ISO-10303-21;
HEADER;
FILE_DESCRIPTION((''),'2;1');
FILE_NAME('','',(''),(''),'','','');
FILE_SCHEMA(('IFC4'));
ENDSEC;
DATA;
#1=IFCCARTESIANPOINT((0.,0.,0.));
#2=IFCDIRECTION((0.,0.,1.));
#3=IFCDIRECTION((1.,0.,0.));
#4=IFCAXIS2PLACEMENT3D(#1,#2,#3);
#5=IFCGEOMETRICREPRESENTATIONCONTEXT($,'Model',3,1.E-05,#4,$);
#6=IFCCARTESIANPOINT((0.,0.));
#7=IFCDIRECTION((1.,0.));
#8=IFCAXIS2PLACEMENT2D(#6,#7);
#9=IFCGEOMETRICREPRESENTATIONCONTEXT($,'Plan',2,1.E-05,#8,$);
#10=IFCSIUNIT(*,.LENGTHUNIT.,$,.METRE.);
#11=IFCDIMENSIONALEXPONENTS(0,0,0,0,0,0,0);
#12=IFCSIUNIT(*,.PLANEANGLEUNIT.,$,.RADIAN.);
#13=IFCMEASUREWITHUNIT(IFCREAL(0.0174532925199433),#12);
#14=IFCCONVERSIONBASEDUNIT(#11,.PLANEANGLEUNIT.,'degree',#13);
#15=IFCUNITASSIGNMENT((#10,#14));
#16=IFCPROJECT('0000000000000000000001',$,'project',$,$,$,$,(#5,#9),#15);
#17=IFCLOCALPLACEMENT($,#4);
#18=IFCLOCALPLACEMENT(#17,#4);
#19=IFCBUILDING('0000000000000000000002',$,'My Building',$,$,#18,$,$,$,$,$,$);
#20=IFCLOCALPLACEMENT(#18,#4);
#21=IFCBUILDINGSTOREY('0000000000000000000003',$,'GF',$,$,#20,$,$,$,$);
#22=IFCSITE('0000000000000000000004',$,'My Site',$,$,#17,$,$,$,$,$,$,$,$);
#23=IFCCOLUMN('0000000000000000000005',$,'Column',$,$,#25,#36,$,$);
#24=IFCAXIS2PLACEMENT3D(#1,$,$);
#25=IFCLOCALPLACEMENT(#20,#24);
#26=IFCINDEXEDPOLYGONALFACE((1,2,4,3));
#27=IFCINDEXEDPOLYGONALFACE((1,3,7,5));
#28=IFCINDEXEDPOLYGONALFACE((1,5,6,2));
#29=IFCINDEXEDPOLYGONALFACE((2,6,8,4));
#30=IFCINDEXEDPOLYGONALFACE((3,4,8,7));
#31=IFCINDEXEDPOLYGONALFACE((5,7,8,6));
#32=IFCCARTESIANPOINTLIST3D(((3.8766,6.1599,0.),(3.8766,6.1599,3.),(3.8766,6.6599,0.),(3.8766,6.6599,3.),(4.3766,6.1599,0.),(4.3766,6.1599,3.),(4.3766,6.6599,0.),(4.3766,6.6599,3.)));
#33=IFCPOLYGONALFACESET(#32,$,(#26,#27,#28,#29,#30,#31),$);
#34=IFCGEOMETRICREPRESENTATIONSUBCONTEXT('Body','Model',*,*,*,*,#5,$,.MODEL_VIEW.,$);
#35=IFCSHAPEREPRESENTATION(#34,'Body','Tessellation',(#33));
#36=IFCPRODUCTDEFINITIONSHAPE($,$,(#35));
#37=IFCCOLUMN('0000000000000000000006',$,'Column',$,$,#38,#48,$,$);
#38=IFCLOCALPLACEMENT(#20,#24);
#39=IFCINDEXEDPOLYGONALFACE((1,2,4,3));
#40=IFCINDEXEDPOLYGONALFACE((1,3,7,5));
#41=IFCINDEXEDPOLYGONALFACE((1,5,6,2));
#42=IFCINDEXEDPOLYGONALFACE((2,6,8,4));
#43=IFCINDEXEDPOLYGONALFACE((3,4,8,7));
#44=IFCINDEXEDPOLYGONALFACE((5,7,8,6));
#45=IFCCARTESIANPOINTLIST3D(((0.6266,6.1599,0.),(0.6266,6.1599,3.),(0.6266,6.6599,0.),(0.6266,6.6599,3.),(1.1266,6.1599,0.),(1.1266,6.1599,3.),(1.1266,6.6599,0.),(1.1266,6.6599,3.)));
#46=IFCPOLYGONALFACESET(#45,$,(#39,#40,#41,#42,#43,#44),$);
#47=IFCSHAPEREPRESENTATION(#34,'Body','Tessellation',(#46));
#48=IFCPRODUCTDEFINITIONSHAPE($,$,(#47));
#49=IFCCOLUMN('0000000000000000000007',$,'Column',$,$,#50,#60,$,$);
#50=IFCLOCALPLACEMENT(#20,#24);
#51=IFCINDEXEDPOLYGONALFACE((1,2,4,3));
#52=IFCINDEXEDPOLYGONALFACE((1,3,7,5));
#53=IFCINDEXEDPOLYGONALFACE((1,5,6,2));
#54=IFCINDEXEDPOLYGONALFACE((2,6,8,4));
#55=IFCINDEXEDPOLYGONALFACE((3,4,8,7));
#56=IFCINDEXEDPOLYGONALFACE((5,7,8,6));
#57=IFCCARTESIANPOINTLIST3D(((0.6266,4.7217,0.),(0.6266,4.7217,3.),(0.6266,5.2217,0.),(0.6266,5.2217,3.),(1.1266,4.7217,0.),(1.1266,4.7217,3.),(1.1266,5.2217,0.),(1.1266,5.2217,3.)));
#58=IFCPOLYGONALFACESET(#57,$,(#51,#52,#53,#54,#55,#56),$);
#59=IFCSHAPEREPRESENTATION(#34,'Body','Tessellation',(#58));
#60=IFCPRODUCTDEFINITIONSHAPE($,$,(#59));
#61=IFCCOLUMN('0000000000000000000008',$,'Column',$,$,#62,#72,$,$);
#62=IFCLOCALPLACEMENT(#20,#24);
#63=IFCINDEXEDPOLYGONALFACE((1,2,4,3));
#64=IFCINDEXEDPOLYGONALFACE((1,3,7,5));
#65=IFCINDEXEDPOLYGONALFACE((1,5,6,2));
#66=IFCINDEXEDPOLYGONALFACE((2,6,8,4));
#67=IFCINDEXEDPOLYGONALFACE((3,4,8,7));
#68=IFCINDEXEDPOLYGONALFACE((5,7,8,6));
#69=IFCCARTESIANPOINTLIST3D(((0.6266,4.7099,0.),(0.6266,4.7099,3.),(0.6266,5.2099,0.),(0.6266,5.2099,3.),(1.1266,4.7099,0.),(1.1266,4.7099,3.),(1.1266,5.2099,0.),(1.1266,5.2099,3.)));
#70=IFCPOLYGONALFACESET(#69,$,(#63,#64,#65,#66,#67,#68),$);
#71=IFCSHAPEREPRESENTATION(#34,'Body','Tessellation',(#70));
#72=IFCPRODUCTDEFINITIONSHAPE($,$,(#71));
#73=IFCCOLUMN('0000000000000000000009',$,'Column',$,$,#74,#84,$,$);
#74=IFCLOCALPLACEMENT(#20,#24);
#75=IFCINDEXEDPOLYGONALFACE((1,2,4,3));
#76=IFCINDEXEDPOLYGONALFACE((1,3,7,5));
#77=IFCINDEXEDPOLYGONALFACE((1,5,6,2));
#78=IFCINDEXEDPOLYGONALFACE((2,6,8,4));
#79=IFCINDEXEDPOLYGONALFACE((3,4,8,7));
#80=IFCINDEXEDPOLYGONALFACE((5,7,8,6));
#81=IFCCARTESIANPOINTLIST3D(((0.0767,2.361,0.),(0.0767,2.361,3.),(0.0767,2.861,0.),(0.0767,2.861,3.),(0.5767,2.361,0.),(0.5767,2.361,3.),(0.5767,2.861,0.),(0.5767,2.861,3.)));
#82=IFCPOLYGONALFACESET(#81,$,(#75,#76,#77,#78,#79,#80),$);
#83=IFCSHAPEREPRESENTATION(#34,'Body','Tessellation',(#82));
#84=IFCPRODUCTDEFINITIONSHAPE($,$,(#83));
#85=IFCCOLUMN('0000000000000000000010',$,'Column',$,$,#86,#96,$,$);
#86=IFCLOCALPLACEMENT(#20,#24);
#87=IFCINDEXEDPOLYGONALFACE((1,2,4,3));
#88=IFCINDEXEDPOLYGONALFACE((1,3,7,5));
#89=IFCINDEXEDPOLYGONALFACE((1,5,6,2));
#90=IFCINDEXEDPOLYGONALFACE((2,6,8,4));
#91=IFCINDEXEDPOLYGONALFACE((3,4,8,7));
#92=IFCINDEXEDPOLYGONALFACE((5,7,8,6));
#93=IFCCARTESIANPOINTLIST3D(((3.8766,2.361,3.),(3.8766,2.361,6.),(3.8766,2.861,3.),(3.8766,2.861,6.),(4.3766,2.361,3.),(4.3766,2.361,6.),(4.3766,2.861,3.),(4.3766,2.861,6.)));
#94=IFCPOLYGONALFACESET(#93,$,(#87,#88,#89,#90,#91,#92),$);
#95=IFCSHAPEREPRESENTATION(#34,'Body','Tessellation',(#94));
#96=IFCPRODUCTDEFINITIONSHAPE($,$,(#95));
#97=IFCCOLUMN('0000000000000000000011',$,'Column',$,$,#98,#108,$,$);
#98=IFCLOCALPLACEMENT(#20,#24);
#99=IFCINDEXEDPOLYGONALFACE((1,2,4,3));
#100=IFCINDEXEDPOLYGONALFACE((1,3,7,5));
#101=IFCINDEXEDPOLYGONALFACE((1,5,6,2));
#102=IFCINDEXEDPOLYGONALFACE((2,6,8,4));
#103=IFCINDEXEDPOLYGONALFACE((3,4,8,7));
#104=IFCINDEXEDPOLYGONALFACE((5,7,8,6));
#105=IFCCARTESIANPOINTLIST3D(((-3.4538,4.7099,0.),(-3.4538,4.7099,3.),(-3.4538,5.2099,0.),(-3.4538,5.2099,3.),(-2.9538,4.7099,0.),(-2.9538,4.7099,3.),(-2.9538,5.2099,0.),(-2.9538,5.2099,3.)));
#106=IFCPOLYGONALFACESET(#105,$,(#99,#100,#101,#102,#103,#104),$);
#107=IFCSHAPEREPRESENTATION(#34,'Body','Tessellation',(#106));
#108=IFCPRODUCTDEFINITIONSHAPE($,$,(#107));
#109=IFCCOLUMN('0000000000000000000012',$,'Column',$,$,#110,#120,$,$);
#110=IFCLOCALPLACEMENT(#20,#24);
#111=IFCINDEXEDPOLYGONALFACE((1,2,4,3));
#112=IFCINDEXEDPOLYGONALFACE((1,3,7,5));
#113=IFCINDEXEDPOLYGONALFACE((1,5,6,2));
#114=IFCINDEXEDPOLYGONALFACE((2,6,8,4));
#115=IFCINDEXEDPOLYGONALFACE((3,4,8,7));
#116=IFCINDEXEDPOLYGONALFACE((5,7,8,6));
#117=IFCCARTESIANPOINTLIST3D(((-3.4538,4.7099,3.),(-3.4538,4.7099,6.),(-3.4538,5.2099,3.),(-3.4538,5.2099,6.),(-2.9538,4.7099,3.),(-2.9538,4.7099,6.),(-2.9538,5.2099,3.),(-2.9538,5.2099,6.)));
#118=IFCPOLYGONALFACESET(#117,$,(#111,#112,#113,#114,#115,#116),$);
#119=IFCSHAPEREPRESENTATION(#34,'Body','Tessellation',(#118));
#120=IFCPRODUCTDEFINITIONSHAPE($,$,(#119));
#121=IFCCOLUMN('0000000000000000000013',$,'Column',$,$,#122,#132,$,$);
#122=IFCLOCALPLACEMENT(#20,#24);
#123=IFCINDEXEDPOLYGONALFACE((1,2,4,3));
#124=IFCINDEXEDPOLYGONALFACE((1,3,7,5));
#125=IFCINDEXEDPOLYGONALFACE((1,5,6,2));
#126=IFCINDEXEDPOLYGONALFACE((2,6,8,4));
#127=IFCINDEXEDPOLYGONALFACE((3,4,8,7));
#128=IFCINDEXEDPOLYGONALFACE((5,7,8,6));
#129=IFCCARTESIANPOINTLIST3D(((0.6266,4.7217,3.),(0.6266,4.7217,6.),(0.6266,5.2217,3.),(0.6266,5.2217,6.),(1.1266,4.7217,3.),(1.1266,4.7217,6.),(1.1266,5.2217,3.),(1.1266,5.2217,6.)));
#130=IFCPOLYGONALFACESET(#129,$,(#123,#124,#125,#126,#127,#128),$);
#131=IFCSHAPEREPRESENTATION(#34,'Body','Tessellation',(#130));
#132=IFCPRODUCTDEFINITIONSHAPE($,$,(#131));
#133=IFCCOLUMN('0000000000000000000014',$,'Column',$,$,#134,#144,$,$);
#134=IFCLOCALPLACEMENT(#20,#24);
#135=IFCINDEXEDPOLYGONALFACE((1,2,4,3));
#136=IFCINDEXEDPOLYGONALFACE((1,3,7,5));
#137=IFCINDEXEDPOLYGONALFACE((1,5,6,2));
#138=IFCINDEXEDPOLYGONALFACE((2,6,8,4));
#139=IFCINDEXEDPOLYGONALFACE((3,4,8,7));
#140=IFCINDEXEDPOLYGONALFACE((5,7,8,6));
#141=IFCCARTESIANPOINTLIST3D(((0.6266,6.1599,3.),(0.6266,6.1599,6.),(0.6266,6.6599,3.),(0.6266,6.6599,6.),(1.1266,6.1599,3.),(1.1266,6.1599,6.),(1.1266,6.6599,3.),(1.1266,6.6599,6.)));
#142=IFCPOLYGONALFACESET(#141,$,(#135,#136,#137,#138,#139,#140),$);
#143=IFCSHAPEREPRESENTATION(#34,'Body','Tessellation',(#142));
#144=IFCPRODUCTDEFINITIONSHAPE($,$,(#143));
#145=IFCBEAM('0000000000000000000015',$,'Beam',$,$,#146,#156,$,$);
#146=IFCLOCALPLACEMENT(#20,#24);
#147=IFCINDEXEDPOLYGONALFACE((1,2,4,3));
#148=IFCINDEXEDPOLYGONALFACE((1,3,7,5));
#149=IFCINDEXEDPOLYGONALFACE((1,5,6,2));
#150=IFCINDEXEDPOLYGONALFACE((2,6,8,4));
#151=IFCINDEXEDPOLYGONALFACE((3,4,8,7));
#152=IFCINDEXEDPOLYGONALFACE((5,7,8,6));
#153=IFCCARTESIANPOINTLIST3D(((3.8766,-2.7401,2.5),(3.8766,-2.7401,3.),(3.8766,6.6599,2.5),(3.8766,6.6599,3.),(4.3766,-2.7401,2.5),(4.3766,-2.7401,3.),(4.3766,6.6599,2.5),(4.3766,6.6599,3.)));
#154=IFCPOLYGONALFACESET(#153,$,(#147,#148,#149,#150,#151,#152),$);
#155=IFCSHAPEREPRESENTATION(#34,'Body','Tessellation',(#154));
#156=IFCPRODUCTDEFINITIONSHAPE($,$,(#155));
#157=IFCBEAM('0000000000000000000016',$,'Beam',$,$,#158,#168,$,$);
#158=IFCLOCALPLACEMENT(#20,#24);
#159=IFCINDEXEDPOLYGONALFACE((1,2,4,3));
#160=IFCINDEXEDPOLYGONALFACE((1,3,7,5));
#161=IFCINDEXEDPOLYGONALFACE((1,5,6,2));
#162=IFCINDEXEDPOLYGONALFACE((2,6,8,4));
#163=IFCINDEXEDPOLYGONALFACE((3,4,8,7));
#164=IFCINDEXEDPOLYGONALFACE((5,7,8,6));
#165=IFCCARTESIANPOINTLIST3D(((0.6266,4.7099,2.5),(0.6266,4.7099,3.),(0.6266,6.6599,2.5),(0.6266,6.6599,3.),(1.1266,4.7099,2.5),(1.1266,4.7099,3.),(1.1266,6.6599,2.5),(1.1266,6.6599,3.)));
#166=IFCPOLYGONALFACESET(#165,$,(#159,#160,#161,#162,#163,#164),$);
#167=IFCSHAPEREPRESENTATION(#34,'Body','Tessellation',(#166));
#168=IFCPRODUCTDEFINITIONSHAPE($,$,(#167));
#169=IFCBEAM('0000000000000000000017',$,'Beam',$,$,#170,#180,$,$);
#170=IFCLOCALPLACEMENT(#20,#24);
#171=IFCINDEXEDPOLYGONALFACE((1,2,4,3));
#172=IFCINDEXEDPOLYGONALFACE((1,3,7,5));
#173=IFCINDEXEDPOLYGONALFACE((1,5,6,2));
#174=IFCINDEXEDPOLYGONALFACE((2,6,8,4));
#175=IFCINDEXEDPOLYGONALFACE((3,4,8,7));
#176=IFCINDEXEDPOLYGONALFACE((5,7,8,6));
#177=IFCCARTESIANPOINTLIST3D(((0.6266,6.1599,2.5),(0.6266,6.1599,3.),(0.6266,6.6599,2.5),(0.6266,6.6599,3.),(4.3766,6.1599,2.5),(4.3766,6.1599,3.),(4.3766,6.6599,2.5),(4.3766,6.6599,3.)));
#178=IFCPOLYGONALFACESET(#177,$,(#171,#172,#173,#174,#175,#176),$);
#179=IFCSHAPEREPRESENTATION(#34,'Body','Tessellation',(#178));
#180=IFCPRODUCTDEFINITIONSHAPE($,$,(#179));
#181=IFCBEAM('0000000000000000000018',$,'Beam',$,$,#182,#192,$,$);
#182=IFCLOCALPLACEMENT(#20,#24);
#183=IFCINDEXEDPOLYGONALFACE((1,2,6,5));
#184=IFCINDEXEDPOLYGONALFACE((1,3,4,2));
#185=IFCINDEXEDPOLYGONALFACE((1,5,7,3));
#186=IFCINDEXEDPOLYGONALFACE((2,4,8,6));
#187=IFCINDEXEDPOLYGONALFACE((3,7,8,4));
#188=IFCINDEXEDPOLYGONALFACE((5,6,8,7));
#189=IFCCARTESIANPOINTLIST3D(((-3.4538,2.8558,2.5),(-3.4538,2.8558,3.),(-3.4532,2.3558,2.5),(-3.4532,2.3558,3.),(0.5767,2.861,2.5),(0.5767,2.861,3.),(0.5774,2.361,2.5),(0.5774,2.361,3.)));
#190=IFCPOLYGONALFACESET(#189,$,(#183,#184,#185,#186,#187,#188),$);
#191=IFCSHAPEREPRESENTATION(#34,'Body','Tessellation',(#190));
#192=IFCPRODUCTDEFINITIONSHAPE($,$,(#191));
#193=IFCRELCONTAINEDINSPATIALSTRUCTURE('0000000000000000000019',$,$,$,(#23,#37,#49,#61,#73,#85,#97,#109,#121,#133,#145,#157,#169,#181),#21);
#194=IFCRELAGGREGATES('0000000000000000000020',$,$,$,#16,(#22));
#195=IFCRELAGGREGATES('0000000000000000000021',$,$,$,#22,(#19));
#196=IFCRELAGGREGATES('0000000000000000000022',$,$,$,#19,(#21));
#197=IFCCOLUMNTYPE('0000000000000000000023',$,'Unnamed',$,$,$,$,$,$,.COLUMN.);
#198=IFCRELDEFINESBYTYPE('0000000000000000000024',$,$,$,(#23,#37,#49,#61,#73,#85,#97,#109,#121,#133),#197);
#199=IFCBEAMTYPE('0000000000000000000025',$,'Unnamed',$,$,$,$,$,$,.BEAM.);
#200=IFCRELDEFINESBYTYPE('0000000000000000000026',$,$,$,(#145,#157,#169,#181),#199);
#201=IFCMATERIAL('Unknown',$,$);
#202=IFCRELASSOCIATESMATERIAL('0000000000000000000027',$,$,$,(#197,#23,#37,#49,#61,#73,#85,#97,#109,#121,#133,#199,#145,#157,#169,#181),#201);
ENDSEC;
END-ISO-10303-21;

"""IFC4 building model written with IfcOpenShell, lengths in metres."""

from ifc_helpers import new_model, entity, si_unit, converted_unit, frame, origin_with_axes, origin_2d_with_axis, place, context, subcontext, project, spatial, rectangle, extrude, material, material_profile, profile_set, profile_usage, type_object, element, save


model = new_model("IFC4")

# Units and contexts
model_context = context("Model", 3, precision=1e-05, world=origin_with_axes())
plan_context = context("Plan", 2, precision=1e-05, world=origin_2d_with_axis())
body_context_1 = subcontext(model_context, "Body", "Model", "MODEL_VIEW")
ifc_project = project(units=[si_unit("LENGTHUNIT", "METRE"), converted_unit("PLANEANGLEUNIT", "degree", entity("IfcReal", 0.0174532925199433), si_unit("PLANEANGLEUNIT", "RADIAN"), dimensions=[0, 0, 0, 0, 0, 0, 0])], contexts=[model_context, plan_context])

# Site, building, storey
site_placement = place(None, origin_with_axes())
site = spatial("IfcSite", under=ifc_project, at=site_placement, Name="My Site")
building_placement = place(site_placement, origin_with_axes())
building = spatial("IfcBuilding", under=site, at=building_placement, Name="My Building")
storey_placement = place(building_placement, origin_with_axes())
storey = spatial("IfcBuildingStorey", under=building, at=storey_placement, Name="GF")

# Columns
ifc_material = material(Name="Unknown")
ifc_material_profile_1 = material_profile(ifc_material, rectangle(XDim=0.5, YDim=0.5))
ifc_profile_set_1 = profile_set([ifc_material_profile_1])
ifc_profile_usage_1 = profile_usage(ifc_profile_set_1, cardinal=5)
column_type = type_object("IfcColumnType", Name="Unnamed", PredefinedType="COLUMN", material=ifc_profile_set_1)
column_1_placement = place(storey_placement, frame((4.1266, 6.4099, 0.0), z_axis=(0.0, 0.0, 1.0), x_axis=(1.0, 0.0, 0.0)))
element("IfcColumn", 1, at=column_1_placement, inside=storey, type_object=column_type, material=ifc_profile_usage_1, Name="Column", context=body_context_1, shape_type="SweptSolid", body=[
    extrude(rectangle(XDim=0.5, YDim=0.5), origin_with_axes(), (0.0, 0.0, 1.0), 3.0),
])
ifc_profile_usage_2 = profile_usage(ifc_profile_set_1, cardinal=5)
column_2_placement = place(storey_placement, frame((0.8766, 6.4099, 0.0), z_axis=(0.0, 0.0, 1.0), x_axis=(1.0, 0.0, 0.0)))
element("IfcColumn", 2, at=column_2_placement, inside=storey, type_object=column_type, material=ifc_profile_usage_2, Name="Column", context=body_context_1, shape_type="SweptSolid", body=[
    extrude(rectangle(XDim=0.5, YDim=0.5), origin_with_axes(), (0.0, 0.0, 1.0), 3.0),
])
ifc_profile_usage_3 = profile_usage(ifc_profile_set_1, cardinal=5)
column_3_placement = place(storey_placement, frame((0.8766, 4.9717, 0.0), z_axis=(0.0, 0.0, 1.0), x_axis=(1.0, 0.0, 0.0)))
element("IfcColumn", 3, at=column_3_placement, inside=storey, type_object=column_type, material=ifc_profile_usage_3, Name="Column", context=body_context_1, shape_type="SweptSolid", body=[
    extrude(rectangle(XDim=0.5, YDim=0.5), origin_with_axes(), (0.0, 0.0, 1.0), 3.0),
])
ifc_profile_usage_4 = profile_usage(ifc_profile_set_1, cardinal=5)
column_4_placement = place(storey_placement, frame((0.8766, 4.9599, 0.0), z_axis=(0.0, 0.0, 1.0), x_axis=(1.0, 0.0, 0.0)))
element("IfcColumn", 4, at=column_4_placement, inside=storey, type_object=column_type, material=ifc_profile_usage_4, Name="Column", context=body_context_1, shape_type="SweptSolid", body=[
    extrude(rectangle(XDim=0.5, YDim=0.5), origin_with_axes(), (0.0, 0.0, 1.0), 3.0),
])
ifc_profile_usage_5 = profile_usage(ifc_profile_set_1, cardinal=5)
column_5_placement = place(storey_placement, frame((0.3267, 2.611, 0.0), z_axis=(0.0, 0.0, 1.0), x_axis=(1.0, 0.0, 0.0)))
element("IfcColumn", 5, at=column_5_placement, inside=storey, type_object=column_type, material=ifc_profile_usage_5, Name="Column", context=body_context_1, shape_type="SweptSolid", body=[
    extrude(rectangle(XDim=0.5, YDim=0.5), origin_with_axes(), (0.0, 0.0, 1.0), 3.0),
])
ifc_profile_usage_6 = profile_usage(ifc_profile_set_1, cardinal=5)
column_6_placement = place(storey_placement, frame((4.1266, 2.611, 3.0), z_axis=(0.0, 0.0, 1.0), x_axis=(1.0, 0.0, 0.0)))
element("IfcColumn", 6, at=column_6_placement, inside=storey, type_object=column_type, material=ifc_profile_usage_6, Name="Column", context=body_context_1, shape_type="SweptSolid", body=[
    extrude(rectangle(XDim=0.5, YDim=0.5), origin_with_axes(), (0.0, 0.0, 1.0), 3.0),
])
ifc_profile_usage_7 = profile_usage(ifc_profile_set_1, cardinal=5)
column_7_placement = place(storey_placement, frame((-3.2038, 4.9599, 0.0), z_axis=(0.0, 0.0, 1.0), x_axis=(1.0, 0.0, 0.0)))
element("IfcColumn", 7, at=column_7_placement, inside=storey, type_object=column_type, material=ifc_profile_usage_7, Name="Column", context=body_context_1, shape_type="SweptSolid", body=[
    extrude(rectangle(XDim=0.5, YDim=0.5), origin_with_axes(), (0.0, 0.0, 1.0), 3.0),
])
ifc_profile_usage_8 = profile_usage(ifc_profile_set_1, cardinal=5)
column_8_placement = place(storey_placement, frame((-3.2038, 4.9599, 3.0), z_axis=(0.0, 0.0, 1.0), x_axis=(1.0, 0.0, 0.0)))
element("IfcColumn", 8, at=column_8_placement, inside=storey, type_object=column_type, material=ifc_profile_usage_8, Name="Column", context=body_context_1, shape_type="SweptSolid", body=[
    extrude(rectangle(XDim=0.5, YDim=0.5), origin_with_axes(), (0.0, 0.0, 1.0), 3.0),
])
ifc_profile_usage_9 = profile_usage(ifc_profile_set_1, cardinal=5)
column_9_placement = place(storey_placement, frame((0.8766, 4.9717, 3.0), z_axis=(0.0, 0.0, 1.0), x_axis=(1.0, 0.0, 0.0)))
element("IfcColumn", 9, at=column_9_placement, inside=storey, type_object=column_type, material=ifc_profile_usage_9, Name="Column", context=body_context_1, shape_type="SweptSolid", body=[
    extrude(rectangle(XDim=0.5, YDim=0.5), origin_with_axes(), (0.0, 0.0, 1.0), 3.0),
])
ifc_profile_usage_10 = profile_usage(ifc_profile_set_1, cardinal=5)
column_10_placement = place(storey_placement, frame((0.8766, 6.4099, 3.0), z_axis=(0.0, 0.0, 1.0), x_axis=(1.0, 0.0, 0.0)))
element("IfcColumn", 10, at=column_10_placement, inside=storey, type_object=column_type, material=ifc_profile_usage_10, Name="Column", context=body_context_1, shape_type="SweptSolid", body=[
    extrude(rectangle(XDim=0.5, YDim=0.5), origin_with_axes(), (0.0, 0.0, 1.0), 3.0),
])

# Beams
ifc_material_profile_2 = material_profile(ifc_material, rectangle(XDim=0.5, YDim=0.5))
ifc_profile_set_2 = profile_set([ifc_material_profile_2])
ifc_profile_usage_11 = profile_usage(ifc_profile_set_2, cardinal=7)
beam_type = type_object("IfcBeamType", Name="Unnamed", PredefinedType="BEAM", material=ifc_profile_set_2)
beam_1_placement = place(storey_placement, frame((4.3766, 6.6599, 3.0), z_axis=(0.0, -1.0, 0.0), x_axis=(1.0, 0.0, 0.0)))
element("IfcBeam", 11, at=beam_1_placement, inside=storey, type_object=beam_type, material=ifc_profile_usage_11, Name="Beam", context=body_context_1, shape_type="SweptSolid", body=[
    extrude(rectangle(XDim=0.5, YDim=0.5), frame((-0.25, -0.25, 0.0), z_axis=(0.0, 0.0, 1.0), x_axis=(1.0, 0.0, 0.0)), (0.0, 0.0, 1.0), 9.4),
])
ifc_profile_usage_12 = profile_usage(ifc_profile_set_2, cardinal=7)
beam_2_placement = place(storey_placement, frame((0.6266, 4.7099, 3.0), z_axis=(0.0, 1.0, 0.0), x_axis=(-1.0, 0.0, 0.0)))
element("IfcBeam", 12, at=beam_2_placement, inside=storey, type_object=beam_type, material=ifc_profile_usage_12, Name="Beam", context=body_context_1, shape_type="SweptSolid", body=[
    extrude(rectangle(XDim=0.5, YDim=0.5), frame((-0.25, -0.25, 0.0), z_axis=(0.0, 0.0, 1.0), x_axis=(1.0, 0.0, 0.0)), (0.0, 0.0, 1.0), 1.95),
])
ifc_profile_usage_13 = profile_usage(ifc_profile_set_2, cardinal=7)
beam_3_placement = place(storey_placement, frame((0.6266, 6.6599, 3.0), z_axis=(1.0, 0.0, 0.0), x_axis=(0.0, 1.0, 0.0)))
element("IfcBeam", 13, at=beam_3_placement, inside=storey, type_object=beam_type, material=ifc_profile_usage_13, Name="Beam", context=body_context_1, shape_type="SweptSolid", body=[
    extrude(rectangle(XDim=0.5, YDim=0.5), frame((-0.25, -0.25, 0.0), z_axis=(0.0, 0.0, 1.0), x_axis=(1.0, 0.0, 0.0)), (0.0, 0.0, 1.0), 3.75),
])
ifc_profile_usage_14 = profile_usage(ifc_profile_set_2, cardinal=7)
beam_4_placement = place(storey_placement, frame((-3.4538, 2.8558, 3.0), z_axis=(0.999999, 0.001295, 0.0), x_axis=(-0.001295, 0.999999, 0.0)))
element("IfcBeam", 14, at=beam_4_placement, inside=storey, type_object=beam_type, material=ifc_profile_usage_14, Name="Beam", context=body_context_1, shape_type="SweptSolid", body=[
    extrude(rectangle(XDim=0.5, YDim=0.5), frame((-0.25, -0.25, 0.0), z_axis=(0.0, 0.0, 1.0), x_axis=(1.0, 0.0, 0.0)), (0.0, 0.0, 1.0), 4.0306),
])

save(model, "model.ifc")
